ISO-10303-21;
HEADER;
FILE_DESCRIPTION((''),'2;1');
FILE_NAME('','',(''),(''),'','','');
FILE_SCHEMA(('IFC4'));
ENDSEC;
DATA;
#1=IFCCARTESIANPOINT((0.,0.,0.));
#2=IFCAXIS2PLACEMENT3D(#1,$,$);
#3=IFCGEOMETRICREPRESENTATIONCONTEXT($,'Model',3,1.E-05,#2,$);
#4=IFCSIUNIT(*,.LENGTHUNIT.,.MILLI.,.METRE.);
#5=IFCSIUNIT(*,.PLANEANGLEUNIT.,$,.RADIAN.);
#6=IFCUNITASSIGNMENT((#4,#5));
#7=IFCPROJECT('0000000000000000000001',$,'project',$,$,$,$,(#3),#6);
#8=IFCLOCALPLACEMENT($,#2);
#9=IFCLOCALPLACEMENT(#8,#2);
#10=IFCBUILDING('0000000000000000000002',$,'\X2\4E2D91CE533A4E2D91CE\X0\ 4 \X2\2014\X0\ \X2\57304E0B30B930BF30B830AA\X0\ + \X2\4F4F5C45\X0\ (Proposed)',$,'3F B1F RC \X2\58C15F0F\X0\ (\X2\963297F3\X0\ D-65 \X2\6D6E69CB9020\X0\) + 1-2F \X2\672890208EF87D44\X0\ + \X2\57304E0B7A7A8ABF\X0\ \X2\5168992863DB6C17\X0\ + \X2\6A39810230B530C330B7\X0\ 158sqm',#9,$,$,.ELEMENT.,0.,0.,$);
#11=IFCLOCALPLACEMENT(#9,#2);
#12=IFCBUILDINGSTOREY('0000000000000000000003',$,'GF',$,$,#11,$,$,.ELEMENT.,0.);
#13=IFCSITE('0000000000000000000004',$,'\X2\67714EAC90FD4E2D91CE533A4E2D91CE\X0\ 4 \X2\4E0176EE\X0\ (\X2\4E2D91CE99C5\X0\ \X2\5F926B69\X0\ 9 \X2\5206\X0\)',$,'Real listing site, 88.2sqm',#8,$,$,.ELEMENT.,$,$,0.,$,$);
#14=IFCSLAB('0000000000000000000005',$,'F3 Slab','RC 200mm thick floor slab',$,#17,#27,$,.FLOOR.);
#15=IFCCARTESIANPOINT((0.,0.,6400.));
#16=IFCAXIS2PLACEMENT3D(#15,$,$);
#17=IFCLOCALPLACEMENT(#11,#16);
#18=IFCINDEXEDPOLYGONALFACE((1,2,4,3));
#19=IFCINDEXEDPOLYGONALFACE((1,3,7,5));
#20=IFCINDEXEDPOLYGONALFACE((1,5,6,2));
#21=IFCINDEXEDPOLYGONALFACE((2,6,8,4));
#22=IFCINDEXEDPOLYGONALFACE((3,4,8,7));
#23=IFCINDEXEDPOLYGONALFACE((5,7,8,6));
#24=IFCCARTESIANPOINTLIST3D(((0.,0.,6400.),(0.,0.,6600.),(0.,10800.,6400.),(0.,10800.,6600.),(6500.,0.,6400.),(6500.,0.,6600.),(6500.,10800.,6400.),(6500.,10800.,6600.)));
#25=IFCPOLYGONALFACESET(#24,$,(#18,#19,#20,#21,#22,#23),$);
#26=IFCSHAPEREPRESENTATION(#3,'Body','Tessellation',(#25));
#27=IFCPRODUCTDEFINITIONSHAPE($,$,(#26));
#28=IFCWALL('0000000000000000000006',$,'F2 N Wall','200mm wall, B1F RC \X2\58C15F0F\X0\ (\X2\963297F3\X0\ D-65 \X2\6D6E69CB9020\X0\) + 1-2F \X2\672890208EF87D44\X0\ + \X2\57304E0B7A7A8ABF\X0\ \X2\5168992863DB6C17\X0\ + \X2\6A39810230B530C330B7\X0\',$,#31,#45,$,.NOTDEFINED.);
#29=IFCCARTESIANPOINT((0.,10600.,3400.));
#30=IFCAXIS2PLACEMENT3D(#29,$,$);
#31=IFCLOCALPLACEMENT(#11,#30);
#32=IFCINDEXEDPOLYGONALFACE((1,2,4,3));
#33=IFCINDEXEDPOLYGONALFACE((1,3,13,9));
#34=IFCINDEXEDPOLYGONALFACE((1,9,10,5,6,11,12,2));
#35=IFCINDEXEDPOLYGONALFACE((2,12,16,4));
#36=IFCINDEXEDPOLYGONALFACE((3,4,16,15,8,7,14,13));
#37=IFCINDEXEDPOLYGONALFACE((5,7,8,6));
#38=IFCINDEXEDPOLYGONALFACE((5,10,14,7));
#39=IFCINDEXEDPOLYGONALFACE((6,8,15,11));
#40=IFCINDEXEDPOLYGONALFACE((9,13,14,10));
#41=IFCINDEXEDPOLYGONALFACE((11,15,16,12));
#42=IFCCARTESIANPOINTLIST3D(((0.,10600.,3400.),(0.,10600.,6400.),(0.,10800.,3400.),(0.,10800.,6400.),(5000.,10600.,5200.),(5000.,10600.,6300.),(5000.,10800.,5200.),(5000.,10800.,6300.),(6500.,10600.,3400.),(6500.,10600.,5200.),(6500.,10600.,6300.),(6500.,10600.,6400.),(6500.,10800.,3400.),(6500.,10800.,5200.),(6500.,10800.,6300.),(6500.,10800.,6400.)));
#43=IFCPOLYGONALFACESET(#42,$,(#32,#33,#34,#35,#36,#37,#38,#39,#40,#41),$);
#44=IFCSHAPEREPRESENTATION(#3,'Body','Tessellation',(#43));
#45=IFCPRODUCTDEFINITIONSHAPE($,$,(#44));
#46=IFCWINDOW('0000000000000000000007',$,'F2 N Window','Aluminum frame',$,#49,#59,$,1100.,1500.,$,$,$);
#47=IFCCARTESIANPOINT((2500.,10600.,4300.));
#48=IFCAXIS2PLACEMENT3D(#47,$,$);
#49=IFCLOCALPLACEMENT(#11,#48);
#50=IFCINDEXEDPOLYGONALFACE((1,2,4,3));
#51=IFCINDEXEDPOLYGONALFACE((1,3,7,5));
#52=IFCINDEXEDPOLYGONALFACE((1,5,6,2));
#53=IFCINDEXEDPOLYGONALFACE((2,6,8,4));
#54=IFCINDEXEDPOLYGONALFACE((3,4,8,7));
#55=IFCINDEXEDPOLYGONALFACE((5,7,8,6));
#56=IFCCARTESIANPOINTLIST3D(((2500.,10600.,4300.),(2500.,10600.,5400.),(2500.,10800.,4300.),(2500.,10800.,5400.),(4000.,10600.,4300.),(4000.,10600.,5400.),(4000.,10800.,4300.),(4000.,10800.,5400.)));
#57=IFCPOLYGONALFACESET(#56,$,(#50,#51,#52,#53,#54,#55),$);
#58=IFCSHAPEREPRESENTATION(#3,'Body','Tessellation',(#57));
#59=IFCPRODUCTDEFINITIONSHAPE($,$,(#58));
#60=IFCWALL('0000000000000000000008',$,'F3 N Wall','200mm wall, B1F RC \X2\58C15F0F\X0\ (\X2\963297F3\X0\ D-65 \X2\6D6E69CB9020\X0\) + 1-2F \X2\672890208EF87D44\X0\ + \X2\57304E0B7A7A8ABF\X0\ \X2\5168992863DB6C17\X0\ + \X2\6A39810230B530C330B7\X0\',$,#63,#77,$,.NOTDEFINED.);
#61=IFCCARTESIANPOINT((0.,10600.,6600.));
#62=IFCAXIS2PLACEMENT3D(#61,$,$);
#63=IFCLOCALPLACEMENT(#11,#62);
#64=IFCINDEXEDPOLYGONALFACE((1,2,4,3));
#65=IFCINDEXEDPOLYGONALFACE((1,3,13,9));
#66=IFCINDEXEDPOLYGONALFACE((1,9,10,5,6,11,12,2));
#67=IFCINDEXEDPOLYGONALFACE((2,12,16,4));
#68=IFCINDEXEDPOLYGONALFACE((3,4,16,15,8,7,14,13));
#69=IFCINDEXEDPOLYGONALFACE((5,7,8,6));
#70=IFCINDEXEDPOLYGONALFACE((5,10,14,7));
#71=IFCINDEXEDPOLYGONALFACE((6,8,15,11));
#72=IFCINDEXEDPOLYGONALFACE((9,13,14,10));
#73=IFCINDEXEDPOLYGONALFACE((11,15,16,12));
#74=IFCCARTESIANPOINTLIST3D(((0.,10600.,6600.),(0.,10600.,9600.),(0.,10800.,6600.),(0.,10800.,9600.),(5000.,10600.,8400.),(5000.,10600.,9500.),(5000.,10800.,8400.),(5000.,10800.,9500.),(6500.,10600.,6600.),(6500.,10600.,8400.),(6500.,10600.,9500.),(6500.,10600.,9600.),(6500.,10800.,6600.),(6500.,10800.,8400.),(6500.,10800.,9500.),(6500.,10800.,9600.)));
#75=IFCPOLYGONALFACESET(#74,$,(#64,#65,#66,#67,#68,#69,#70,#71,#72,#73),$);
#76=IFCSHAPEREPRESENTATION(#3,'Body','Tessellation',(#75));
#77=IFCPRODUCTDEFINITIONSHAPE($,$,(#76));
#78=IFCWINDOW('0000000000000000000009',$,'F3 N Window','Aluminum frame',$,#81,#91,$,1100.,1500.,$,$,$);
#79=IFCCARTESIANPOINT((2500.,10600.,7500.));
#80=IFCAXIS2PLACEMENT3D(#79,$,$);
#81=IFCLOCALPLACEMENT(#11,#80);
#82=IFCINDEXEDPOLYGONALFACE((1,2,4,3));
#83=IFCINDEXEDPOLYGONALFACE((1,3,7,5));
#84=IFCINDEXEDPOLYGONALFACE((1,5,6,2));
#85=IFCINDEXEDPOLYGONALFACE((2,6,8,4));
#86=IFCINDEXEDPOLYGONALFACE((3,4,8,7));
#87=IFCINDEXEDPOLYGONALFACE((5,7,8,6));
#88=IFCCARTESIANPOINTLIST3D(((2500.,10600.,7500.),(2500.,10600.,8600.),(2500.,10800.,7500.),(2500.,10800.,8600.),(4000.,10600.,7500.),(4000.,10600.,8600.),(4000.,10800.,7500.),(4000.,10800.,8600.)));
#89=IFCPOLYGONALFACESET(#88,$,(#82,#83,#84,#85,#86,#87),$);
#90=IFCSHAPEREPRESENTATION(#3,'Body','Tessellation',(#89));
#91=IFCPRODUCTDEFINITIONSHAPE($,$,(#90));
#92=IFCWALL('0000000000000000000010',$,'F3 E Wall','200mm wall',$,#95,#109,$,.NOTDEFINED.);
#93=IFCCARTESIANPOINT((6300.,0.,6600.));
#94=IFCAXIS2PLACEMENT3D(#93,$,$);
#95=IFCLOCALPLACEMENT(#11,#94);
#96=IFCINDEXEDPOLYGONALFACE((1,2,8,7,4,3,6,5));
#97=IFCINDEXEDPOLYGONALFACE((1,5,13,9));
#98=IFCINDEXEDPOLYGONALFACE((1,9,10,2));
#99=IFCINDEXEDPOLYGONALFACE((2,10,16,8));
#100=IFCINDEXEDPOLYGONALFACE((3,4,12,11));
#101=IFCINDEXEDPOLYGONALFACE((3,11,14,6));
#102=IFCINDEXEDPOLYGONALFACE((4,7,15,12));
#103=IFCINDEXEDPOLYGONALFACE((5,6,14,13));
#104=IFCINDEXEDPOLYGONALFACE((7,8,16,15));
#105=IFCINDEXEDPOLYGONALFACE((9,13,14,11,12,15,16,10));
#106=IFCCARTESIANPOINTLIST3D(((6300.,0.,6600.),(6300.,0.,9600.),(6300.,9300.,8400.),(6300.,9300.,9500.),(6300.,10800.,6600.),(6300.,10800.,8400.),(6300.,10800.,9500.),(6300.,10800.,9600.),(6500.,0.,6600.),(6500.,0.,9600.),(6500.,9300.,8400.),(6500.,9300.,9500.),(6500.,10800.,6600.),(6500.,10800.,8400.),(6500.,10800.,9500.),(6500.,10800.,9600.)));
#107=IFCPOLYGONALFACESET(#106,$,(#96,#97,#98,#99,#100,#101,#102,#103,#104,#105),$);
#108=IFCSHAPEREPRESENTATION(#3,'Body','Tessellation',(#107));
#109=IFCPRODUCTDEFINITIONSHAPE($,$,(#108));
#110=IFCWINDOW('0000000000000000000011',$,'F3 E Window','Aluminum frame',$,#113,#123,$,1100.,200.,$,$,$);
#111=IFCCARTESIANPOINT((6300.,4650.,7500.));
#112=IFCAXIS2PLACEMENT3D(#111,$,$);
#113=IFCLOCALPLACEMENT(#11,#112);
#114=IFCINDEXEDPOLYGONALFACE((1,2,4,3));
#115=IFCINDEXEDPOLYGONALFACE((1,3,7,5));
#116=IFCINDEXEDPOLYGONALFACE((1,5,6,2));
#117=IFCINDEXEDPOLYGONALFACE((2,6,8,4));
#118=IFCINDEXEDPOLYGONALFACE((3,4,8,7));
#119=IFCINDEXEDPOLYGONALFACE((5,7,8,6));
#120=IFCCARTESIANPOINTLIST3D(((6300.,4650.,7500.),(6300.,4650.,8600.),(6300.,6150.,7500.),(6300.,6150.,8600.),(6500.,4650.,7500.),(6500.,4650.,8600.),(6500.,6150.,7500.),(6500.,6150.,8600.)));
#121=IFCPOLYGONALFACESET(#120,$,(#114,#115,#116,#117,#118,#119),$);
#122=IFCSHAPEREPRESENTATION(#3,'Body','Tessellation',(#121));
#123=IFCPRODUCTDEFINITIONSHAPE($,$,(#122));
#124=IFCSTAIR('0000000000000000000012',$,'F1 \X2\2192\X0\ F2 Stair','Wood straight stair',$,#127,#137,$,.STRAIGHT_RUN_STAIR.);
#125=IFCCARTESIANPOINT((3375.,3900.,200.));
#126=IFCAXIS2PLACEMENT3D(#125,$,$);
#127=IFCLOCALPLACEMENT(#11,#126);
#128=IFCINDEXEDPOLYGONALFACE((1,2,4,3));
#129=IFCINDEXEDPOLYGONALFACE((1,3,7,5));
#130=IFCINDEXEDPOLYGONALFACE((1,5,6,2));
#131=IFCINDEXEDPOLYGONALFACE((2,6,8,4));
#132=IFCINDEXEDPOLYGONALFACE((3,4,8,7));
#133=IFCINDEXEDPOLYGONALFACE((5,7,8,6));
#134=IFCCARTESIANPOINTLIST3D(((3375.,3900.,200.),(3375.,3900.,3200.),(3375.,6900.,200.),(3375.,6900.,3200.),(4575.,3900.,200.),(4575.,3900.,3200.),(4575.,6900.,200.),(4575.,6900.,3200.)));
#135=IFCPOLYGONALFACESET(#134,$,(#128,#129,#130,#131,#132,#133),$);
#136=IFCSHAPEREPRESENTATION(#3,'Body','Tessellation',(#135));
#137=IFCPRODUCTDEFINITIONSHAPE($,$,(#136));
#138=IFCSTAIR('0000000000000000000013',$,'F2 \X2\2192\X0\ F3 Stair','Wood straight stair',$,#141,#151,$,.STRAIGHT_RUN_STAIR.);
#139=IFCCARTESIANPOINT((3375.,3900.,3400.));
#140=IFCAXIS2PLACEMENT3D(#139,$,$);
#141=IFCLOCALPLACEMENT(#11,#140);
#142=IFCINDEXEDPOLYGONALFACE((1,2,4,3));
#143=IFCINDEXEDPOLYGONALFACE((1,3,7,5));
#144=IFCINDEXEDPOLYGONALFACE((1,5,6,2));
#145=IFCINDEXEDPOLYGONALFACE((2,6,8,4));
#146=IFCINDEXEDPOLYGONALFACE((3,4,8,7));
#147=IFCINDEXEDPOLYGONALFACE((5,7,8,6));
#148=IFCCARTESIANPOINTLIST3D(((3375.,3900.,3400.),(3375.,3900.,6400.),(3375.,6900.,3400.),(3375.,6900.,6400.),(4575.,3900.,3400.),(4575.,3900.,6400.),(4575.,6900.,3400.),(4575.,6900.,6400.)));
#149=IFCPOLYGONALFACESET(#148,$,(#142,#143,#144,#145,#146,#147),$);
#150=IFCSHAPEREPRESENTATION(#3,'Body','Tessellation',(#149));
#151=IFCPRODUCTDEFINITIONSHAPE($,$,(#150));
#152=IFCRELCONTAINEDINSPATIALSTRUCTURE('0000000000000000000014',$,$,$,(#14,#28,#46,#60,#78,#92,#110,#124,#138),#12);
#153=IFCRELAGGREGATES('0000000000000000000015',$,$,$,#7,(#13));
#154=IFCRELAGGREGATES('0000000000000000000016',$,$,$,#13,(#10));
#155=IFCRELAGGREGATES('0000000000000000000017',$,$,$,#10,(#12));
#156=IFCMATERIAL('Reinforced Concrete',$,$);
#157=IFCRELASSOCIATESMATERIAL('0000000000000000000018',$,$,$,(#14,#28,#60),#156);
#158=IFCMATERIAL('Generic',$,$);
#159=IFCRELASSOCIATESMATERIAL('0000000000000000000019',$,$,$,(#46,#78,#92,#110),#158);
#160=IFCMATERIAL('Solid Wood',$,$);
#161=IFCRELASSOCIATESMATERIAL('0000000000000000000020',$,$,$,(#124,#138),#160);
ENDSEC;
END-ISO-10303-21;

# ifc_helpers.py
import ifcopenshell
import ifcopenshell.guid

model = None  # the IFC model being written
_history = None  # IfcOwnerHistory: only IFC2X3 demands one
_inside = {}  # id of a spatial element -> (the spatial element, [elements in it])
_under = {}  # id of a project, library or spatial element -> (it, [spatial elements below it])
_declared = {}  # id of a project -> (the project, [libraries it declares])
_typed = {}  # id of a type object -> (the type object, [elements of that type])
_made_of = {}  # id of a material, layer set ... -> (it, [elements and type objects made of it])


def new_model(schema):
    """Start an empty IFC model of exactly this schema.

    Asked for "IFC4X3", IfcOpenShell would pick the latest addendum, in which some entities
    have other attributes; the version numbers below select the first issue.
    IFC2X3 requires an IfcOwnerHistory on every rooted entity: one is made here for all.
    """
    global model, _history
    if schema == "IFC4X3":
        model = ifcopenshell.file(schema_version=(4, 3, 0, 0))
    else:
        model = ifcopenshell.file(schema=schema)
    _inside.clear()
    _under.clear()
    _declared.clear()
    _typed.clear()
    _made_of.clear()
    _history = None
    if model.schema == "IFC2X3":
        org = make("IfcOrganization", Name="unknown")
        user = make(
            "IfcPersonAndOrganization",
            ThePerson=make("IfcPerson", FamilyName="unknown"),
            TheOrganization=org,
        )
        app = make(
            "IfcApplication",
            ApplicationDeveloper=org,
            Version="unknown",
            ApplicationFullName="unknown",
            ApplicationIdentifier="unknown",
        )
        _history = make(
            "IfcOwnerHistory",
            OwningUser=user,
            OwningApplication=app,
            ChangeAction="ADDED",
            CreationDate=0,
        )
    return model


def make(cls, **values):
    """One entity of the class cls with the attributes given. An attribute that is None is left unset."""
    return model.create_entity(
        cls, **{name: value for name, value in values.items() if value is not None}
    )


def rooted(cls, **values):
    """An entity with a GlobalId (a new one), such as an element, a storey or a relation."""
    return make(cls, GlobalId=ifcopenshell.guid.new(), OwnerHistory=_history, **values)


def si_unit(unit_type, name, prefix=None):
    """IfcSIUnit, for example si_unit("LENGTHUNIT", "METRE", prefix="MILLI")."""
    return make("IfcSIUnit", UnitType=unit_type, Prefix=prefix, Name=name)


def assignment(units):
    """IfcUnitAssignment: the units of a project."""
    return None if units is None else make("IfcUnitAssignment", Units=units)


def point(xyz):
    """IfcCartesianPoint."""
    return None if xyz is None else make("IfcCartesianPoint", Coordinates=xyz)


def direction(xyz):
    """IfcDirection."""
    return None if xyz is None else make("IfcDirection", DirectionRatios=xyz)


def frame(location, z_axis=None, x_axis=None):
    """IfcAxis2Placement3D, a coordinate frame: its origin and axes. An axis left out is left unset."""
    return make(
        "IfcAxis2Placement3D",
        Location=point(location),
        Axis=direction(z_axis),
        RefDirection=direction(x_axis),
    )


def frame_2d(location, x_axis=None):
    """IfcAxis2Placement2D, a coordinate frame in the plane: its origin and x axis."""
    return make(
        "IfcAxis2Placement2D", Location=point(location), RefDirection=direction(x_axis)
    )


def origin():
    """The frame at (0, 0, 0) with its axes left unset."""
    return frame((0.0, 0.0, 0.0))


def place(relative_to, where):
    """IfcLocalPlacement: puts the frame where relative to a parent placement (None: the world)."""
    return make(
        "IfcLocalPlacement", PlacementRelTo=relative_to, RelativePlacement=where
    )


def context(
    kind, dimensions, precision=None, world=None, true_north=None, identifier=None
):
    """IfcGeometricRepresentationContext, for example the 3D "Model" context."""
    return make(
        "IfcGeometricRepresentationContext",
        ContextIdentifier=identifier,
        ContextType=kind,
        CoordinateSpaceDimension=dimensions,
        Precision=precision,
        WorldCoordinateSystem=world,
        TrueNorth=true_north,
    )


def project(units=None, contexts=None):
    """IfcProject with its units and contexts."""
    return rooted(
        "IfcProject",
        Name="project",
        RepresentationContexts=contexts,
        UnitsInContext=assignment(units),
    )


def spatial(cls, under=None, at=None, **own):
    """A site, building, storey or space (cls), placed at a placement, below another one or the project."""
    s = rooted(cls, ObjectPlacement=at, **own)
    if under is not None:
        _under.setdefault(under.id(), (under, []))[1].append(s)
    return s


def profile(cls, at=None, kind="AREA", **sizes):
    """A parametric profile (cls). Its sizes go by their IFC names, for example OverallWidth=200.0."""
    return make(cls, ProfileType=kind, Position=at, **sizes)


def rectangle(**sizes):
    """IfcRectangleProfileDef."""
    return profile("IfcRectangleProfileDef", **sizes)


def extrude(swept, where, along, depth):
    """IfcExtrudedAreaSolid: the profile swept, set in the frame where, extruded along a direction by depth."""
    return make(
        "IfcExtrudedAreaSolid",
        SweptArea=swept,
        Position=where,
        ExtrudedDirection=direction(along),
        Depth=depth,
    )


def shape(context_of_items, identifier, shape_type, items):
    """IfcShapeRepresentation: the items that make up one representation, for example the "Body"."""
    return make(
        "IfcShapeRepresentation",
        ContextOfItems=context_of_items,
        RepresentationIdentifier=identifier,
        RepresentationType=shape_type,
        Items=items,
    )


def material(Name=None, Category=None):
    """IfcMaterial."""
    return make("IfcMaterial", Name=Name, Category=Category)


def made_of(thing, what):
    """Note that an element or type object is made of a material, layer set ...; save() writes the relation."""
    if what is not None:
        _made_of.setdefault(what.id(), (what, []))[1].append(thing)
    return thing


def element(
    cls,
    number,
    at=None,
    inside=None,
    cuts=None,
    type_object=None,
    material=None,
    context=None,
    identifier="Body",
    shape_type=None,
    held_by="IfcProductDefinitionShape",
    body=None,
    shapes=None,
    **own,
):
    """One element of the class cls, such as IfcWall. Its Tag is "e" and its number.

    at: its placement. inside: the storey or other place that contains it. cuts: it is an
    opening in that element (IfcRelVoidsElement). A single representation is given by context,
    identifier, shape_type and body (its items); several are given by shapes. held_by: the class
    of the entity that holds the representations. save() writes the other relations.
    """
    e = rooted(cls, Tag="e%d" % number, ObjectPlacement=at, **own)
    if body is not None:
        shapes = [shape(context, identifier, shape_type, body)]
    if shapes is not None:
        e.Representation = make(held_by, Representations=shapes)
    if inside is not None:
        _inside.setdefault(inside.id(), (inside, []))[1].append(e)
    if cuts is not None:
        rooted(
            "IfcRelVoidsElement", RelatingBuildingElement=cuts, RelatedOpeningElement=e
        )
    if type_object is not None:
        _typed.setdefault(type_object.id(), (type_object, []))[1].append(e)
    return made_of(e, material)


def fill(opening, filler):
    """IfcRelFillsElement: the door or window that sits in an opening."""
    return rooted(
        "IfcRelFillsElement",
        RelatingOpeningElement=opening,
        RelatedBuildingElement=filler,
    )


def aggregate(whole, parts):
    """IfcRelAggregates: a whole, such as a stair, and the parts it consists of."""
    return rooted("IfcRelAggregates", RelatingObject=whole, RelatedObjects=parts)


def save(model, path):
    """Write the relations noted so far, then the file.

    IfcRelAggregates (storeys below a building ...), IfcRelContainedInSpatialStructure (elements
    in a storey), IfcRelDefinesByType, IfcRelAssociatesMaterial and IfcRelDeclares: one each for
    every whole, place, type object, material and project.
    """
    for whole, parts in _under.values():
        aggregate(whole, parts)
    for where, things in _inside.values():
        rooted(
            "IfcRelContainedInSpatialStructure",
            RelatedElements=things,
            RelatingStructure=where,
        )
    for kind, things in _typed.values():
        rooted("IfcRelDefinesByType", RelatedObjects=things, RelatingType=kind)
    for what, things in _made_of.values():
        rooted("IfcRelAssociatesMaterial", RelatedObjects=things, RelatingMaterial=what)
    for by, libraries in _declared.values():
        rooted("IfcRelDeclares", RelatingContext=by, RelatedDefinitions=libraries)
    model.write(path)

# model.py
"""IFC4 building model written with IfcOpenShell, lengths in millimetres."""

from ifc_helpers import new_model, si_unit, frame, frame_2d, origin, place, context, project, spatial, rectangle, extrude, material, element, fill, save


model = new_model("IFC4")

# Units and contexts
model_context = context("Model", 3, precision=1e-05, world=origin())
ifc_project = project(units=[si_unit("LENGTHUNIT", "METRE", prefix="MILLI"), si_unit("PLANEANGLEUNIT", "RADIAN")], contexts=[model_context])

# Site, building, storey
site_placement = place(None, origin())
site = spatial("IfcSite", under=ifc_project, at=site_placement, Name="東京都中野区中野 4 丁目 (中野駅 徒歩 9 分)", ObjectType="Real listing site, 88.2sqm", CompositionType="ELEMENT", RefElevation=0.0)
building_placement = place(site_placement, origin())
building = spatial("IfcBuilding", under=site, at=building_placement, Name="中野区中野 4 — 地下スタジオ + 住居 (Proposed)", ObjectType="3F B1F RC 壁式 (防音 D-65 浮構造) + 1-2F 木造軸組 + 地下空調 全館換気 + 樹脂サッシ 158sqm", CompositionType="ELEMENT", ElevationOfRefHeight=0.0, ElevationOfTerrain=0.0)
storey_placement = place(building_placement, origin())
storey = spatial("IfcBuildingStorey", under=building, at=storey_placement, Name="GF", CompositionType="ELEMENT", Elevation=0.0)

# Slab
ifc_material_1 = material(Name="Reinforced Concrete")
slab_placement = place(storey_placement, frame((0.0, 0.0, 6400.0)))
element("IfcSlab", 1, at=slab_placement, inside=storey, material=ifc_material_1, Name="F3 Slab", Description="RC 200mm thick floor slab", PredefinedType="FLOOR", context=model_context, shape_type="SweptSolid", body=[
    extrude(rectangle(XDim=6500.0, YDim=10800.0, at=frame_2d((3250.0, 5400.0))), frame((0.0, 0.0, 6400.0)), (0.0, 0.0, 1.0), 200.0),
])

# Walls, openings, windows
ifc_material_2 = material(Name="Generic")
wall_1_placement = place(storey_placement, frame((0.0, 10600.0, 3400.0)))
wall_1 = element("IfcWall", 2, at=wall_1_placement, inside=storey, material=ifc_material_1, Name="F2 N Wall", Description="200mm wall, B1F RC 壁式 (防音 D-65 浮構造) + 1-2F 木造軸組 + 地下空調 全館換気 + 樹脂サッシ", PredefinedType="NOTDEFINED", context=model_context, shape_type="SweptSolid", body=[
    extrude(rectangle(XDim=6500.0, YDim=200.0, at=frame_2d((3250.0, 100.0))), frame((0.0, 10600.0, 3400.0)), (0.0, 0.0, 1.0), 3000.0),
])
opening_1_placement = place(storey_placement, frame((2500.0, 10600.0, 4300.0)))
opening_1 = element("IfcOpeningElement", 3, at=opening_1_placement, cuts=wall_1, PredefinedType="NOTDEFINED", context=model_context, shape_type="SweptSolid", body=[
    extrude(rectangle(XDim=1500.0, YDim=200.0, at=frame_2d((750.0, 100.0))), frame((2500.0, 10600.0, 4300.0)), (0.0, 0.0, 1.0), 1100.0),
])
window_1_placement = place(storey_placement, frame((2500.0, 10600.0, 4300.0)))
window_1 = element("IfcWindow", 4, at=window_1_placement, inside=storey, material=ifc_material_2, Name="F2 N Window", Description="Aluminum frame", OverallHeight=1100.0, OverallWidth=1500.0, context=model_context, shape_type="SweptSolid", body=[
    extrude(rectangle(XDim=1500.0, YDim=200.0, at=frame_2d((750.0, 100.0))), frame((2500.0, 10600.0, 4300.0)), (0.0, 0.0, 1.0), 1100.0),
])
fill(opening_1, window_1)
wall_2_placement = place(storey_placement, frame((0.0, 10600.0, 6600.0)))
wall_2 = element("IfcWall", 5, at=wall_2_placement, inside=storey, material=ifc_material_1, Name="F3 N Wall", Description="200mm wall, B1F RC 壁式 (防音 D-65 浮構造) + 1-2F 木造軸組 + 地下空調 全館換気 + 樹脂サッシ", PredefinedType="NOTDEFINED", context=model_context, shape_type="SweptSolid", body=[
    extrude(rectangle(XDim=6500.0, YDim=200.0, at=frame_2d((3250.0, 100.0))), frame((0.0, 10600.0, 6600.0)), (0.0, 0.0, 1.0), 3000.0),
])
opening_2_placement = place(storey_placement, frame((2500.0, 10600.0, 7500.0)))
opening_2 = element("IfcOpeningElement", 6, at=opening_2_placement, cuts=wall_2, PredefinedType="NOTDEFINED", context=model_context, shape_type="SweptSolid", body=[
    extrude(rectangle(XDim=1500.0, YDim=200.0, at=frame_2d((750.0, 100.0))), frame((2500.0, 10600.0, 7500.0)), (0.0, 0.0, 1.0), 1100.0),
])
window_2_placement = place(storey_placement, frame((2500.0, 10600.0, 7500.0)))
window_2 = element("IfcWindow", 7, at=window_2_placement, inside=storey, material=ifc_material_2, Name="F3 N Window", Description="Aluminum frame", OverallHeight=1100.0, OverallWidth=1500.0, context=model_context, shape_type="SweptSolid", body=[
    extrude(rectangle(XDim=1500.0, YDim=200.0, at=frame_2d((750.0, 100.0))), frame((2500.0, 10600.0, 7500.0)), (0.0, 0.0, 1.0), 1100.0),
])
fill(opening_2, window_2)
wall_3_placement = place(storey_placement, frame((6300.0, 0.0, 6600.0)))
wall_3 = element("IfcWall", 8, at=wall_3_placement, inside=storey, material=ifc_material_2, Name="F3 E Wall", Description="200mm wall", PredefinedType="NOTDEFINED", context=model_context, shape_type="SweptSolid", body=[
    extrude(rectangle(XDim=200.0, YDim=10800.0, at=frame_2d((100.0, 5400.0))), frame((6300.0, 0.0, 6600.0)), (0.0, 0.0, 1.0), 3000.0),
])
opening_3_placement = place(storey_placement, frame((6300.0, 4650.0, 7500.0)))
opening_3 = element("IfcOpeningElement", 9, at=opening_3_placement, cuts=wall_3, PredefinedType="NOTDEFINED", context=model_context, shape_type="SweptSolid", body=[
    extrude(rectangle(XDim=200.0, YDim=1500.0, at=frame_2d((100.0, 750.0))), frame((6300.0, 4650.0, 7500.0)), (0.0, 0.0, 1.0), 1100.0),
])
window_3_placement = place(storey_placement, frame((6300.0, 4650.0, 7500.0)))
window_3 = element("IfcWindow", 10, at=window_3_placement, inside=storey, material=ifc_material_2, Name="F3 E Window", Description="Aluminum frame", OverallHeight=1100.0, OverallWidth=200.0, context=model_context, shape_type="SweptSolid", body=[
    extrude(rectangle(XDim=200.0, YDim=1500.0, at=frame_2d((100.0, 750.0))), frame((6300.0, 4650.0, 7500.0)), (0.0, 0.0, 1.0), 1100.0),
])
fill(opening_3, window_3)

# Stairs
ifc_material_3 = material(Name="Solid Wood")
stair_1_placement = place(storey_placement, frame((3375.0, 3900.0, 200.0)))
element("IfcStair", 11, at=stair_1_placement, inside=storey, material=ifc_material_3, Name="F1 → F2 Stair", Description="Wood straight stair", PredefinedType="STRAIGHT_RUN_STAIR", context=model_context, shape_type="SweptSolid", body=[
    extrude(rectangle(XDim=1200.0, YDim=3000.0, at=frame_2d((600.0, 1500.0))), frame((3375.0, 3900.0, 200.0)), (0.0, 0.0, 1.0), 3000.0),
])
stair_2_placement = place(storey_placement, frame((3375.0, 3900.0, 3400.0)))
element("IfcStair", 12, at=stair_2_placement, inside=storey, material=ifc_material_3, Name="F2 → F3 Stair", Description="Wood straight stair", PredefinedType="STRAIGHT_RUN_STAIR", context=model_context, shape_type="SweptSolid", body=[
    extrude(rectangle(XDim=1200.0, YDim=3000.0, at=frame_2d((600.0, 1500.0))), frame((3375.0, 3900.0, 3400.0)), (0.0, 0.0, 1.0), 3000.0),
])

save(model, "model.ifc")
